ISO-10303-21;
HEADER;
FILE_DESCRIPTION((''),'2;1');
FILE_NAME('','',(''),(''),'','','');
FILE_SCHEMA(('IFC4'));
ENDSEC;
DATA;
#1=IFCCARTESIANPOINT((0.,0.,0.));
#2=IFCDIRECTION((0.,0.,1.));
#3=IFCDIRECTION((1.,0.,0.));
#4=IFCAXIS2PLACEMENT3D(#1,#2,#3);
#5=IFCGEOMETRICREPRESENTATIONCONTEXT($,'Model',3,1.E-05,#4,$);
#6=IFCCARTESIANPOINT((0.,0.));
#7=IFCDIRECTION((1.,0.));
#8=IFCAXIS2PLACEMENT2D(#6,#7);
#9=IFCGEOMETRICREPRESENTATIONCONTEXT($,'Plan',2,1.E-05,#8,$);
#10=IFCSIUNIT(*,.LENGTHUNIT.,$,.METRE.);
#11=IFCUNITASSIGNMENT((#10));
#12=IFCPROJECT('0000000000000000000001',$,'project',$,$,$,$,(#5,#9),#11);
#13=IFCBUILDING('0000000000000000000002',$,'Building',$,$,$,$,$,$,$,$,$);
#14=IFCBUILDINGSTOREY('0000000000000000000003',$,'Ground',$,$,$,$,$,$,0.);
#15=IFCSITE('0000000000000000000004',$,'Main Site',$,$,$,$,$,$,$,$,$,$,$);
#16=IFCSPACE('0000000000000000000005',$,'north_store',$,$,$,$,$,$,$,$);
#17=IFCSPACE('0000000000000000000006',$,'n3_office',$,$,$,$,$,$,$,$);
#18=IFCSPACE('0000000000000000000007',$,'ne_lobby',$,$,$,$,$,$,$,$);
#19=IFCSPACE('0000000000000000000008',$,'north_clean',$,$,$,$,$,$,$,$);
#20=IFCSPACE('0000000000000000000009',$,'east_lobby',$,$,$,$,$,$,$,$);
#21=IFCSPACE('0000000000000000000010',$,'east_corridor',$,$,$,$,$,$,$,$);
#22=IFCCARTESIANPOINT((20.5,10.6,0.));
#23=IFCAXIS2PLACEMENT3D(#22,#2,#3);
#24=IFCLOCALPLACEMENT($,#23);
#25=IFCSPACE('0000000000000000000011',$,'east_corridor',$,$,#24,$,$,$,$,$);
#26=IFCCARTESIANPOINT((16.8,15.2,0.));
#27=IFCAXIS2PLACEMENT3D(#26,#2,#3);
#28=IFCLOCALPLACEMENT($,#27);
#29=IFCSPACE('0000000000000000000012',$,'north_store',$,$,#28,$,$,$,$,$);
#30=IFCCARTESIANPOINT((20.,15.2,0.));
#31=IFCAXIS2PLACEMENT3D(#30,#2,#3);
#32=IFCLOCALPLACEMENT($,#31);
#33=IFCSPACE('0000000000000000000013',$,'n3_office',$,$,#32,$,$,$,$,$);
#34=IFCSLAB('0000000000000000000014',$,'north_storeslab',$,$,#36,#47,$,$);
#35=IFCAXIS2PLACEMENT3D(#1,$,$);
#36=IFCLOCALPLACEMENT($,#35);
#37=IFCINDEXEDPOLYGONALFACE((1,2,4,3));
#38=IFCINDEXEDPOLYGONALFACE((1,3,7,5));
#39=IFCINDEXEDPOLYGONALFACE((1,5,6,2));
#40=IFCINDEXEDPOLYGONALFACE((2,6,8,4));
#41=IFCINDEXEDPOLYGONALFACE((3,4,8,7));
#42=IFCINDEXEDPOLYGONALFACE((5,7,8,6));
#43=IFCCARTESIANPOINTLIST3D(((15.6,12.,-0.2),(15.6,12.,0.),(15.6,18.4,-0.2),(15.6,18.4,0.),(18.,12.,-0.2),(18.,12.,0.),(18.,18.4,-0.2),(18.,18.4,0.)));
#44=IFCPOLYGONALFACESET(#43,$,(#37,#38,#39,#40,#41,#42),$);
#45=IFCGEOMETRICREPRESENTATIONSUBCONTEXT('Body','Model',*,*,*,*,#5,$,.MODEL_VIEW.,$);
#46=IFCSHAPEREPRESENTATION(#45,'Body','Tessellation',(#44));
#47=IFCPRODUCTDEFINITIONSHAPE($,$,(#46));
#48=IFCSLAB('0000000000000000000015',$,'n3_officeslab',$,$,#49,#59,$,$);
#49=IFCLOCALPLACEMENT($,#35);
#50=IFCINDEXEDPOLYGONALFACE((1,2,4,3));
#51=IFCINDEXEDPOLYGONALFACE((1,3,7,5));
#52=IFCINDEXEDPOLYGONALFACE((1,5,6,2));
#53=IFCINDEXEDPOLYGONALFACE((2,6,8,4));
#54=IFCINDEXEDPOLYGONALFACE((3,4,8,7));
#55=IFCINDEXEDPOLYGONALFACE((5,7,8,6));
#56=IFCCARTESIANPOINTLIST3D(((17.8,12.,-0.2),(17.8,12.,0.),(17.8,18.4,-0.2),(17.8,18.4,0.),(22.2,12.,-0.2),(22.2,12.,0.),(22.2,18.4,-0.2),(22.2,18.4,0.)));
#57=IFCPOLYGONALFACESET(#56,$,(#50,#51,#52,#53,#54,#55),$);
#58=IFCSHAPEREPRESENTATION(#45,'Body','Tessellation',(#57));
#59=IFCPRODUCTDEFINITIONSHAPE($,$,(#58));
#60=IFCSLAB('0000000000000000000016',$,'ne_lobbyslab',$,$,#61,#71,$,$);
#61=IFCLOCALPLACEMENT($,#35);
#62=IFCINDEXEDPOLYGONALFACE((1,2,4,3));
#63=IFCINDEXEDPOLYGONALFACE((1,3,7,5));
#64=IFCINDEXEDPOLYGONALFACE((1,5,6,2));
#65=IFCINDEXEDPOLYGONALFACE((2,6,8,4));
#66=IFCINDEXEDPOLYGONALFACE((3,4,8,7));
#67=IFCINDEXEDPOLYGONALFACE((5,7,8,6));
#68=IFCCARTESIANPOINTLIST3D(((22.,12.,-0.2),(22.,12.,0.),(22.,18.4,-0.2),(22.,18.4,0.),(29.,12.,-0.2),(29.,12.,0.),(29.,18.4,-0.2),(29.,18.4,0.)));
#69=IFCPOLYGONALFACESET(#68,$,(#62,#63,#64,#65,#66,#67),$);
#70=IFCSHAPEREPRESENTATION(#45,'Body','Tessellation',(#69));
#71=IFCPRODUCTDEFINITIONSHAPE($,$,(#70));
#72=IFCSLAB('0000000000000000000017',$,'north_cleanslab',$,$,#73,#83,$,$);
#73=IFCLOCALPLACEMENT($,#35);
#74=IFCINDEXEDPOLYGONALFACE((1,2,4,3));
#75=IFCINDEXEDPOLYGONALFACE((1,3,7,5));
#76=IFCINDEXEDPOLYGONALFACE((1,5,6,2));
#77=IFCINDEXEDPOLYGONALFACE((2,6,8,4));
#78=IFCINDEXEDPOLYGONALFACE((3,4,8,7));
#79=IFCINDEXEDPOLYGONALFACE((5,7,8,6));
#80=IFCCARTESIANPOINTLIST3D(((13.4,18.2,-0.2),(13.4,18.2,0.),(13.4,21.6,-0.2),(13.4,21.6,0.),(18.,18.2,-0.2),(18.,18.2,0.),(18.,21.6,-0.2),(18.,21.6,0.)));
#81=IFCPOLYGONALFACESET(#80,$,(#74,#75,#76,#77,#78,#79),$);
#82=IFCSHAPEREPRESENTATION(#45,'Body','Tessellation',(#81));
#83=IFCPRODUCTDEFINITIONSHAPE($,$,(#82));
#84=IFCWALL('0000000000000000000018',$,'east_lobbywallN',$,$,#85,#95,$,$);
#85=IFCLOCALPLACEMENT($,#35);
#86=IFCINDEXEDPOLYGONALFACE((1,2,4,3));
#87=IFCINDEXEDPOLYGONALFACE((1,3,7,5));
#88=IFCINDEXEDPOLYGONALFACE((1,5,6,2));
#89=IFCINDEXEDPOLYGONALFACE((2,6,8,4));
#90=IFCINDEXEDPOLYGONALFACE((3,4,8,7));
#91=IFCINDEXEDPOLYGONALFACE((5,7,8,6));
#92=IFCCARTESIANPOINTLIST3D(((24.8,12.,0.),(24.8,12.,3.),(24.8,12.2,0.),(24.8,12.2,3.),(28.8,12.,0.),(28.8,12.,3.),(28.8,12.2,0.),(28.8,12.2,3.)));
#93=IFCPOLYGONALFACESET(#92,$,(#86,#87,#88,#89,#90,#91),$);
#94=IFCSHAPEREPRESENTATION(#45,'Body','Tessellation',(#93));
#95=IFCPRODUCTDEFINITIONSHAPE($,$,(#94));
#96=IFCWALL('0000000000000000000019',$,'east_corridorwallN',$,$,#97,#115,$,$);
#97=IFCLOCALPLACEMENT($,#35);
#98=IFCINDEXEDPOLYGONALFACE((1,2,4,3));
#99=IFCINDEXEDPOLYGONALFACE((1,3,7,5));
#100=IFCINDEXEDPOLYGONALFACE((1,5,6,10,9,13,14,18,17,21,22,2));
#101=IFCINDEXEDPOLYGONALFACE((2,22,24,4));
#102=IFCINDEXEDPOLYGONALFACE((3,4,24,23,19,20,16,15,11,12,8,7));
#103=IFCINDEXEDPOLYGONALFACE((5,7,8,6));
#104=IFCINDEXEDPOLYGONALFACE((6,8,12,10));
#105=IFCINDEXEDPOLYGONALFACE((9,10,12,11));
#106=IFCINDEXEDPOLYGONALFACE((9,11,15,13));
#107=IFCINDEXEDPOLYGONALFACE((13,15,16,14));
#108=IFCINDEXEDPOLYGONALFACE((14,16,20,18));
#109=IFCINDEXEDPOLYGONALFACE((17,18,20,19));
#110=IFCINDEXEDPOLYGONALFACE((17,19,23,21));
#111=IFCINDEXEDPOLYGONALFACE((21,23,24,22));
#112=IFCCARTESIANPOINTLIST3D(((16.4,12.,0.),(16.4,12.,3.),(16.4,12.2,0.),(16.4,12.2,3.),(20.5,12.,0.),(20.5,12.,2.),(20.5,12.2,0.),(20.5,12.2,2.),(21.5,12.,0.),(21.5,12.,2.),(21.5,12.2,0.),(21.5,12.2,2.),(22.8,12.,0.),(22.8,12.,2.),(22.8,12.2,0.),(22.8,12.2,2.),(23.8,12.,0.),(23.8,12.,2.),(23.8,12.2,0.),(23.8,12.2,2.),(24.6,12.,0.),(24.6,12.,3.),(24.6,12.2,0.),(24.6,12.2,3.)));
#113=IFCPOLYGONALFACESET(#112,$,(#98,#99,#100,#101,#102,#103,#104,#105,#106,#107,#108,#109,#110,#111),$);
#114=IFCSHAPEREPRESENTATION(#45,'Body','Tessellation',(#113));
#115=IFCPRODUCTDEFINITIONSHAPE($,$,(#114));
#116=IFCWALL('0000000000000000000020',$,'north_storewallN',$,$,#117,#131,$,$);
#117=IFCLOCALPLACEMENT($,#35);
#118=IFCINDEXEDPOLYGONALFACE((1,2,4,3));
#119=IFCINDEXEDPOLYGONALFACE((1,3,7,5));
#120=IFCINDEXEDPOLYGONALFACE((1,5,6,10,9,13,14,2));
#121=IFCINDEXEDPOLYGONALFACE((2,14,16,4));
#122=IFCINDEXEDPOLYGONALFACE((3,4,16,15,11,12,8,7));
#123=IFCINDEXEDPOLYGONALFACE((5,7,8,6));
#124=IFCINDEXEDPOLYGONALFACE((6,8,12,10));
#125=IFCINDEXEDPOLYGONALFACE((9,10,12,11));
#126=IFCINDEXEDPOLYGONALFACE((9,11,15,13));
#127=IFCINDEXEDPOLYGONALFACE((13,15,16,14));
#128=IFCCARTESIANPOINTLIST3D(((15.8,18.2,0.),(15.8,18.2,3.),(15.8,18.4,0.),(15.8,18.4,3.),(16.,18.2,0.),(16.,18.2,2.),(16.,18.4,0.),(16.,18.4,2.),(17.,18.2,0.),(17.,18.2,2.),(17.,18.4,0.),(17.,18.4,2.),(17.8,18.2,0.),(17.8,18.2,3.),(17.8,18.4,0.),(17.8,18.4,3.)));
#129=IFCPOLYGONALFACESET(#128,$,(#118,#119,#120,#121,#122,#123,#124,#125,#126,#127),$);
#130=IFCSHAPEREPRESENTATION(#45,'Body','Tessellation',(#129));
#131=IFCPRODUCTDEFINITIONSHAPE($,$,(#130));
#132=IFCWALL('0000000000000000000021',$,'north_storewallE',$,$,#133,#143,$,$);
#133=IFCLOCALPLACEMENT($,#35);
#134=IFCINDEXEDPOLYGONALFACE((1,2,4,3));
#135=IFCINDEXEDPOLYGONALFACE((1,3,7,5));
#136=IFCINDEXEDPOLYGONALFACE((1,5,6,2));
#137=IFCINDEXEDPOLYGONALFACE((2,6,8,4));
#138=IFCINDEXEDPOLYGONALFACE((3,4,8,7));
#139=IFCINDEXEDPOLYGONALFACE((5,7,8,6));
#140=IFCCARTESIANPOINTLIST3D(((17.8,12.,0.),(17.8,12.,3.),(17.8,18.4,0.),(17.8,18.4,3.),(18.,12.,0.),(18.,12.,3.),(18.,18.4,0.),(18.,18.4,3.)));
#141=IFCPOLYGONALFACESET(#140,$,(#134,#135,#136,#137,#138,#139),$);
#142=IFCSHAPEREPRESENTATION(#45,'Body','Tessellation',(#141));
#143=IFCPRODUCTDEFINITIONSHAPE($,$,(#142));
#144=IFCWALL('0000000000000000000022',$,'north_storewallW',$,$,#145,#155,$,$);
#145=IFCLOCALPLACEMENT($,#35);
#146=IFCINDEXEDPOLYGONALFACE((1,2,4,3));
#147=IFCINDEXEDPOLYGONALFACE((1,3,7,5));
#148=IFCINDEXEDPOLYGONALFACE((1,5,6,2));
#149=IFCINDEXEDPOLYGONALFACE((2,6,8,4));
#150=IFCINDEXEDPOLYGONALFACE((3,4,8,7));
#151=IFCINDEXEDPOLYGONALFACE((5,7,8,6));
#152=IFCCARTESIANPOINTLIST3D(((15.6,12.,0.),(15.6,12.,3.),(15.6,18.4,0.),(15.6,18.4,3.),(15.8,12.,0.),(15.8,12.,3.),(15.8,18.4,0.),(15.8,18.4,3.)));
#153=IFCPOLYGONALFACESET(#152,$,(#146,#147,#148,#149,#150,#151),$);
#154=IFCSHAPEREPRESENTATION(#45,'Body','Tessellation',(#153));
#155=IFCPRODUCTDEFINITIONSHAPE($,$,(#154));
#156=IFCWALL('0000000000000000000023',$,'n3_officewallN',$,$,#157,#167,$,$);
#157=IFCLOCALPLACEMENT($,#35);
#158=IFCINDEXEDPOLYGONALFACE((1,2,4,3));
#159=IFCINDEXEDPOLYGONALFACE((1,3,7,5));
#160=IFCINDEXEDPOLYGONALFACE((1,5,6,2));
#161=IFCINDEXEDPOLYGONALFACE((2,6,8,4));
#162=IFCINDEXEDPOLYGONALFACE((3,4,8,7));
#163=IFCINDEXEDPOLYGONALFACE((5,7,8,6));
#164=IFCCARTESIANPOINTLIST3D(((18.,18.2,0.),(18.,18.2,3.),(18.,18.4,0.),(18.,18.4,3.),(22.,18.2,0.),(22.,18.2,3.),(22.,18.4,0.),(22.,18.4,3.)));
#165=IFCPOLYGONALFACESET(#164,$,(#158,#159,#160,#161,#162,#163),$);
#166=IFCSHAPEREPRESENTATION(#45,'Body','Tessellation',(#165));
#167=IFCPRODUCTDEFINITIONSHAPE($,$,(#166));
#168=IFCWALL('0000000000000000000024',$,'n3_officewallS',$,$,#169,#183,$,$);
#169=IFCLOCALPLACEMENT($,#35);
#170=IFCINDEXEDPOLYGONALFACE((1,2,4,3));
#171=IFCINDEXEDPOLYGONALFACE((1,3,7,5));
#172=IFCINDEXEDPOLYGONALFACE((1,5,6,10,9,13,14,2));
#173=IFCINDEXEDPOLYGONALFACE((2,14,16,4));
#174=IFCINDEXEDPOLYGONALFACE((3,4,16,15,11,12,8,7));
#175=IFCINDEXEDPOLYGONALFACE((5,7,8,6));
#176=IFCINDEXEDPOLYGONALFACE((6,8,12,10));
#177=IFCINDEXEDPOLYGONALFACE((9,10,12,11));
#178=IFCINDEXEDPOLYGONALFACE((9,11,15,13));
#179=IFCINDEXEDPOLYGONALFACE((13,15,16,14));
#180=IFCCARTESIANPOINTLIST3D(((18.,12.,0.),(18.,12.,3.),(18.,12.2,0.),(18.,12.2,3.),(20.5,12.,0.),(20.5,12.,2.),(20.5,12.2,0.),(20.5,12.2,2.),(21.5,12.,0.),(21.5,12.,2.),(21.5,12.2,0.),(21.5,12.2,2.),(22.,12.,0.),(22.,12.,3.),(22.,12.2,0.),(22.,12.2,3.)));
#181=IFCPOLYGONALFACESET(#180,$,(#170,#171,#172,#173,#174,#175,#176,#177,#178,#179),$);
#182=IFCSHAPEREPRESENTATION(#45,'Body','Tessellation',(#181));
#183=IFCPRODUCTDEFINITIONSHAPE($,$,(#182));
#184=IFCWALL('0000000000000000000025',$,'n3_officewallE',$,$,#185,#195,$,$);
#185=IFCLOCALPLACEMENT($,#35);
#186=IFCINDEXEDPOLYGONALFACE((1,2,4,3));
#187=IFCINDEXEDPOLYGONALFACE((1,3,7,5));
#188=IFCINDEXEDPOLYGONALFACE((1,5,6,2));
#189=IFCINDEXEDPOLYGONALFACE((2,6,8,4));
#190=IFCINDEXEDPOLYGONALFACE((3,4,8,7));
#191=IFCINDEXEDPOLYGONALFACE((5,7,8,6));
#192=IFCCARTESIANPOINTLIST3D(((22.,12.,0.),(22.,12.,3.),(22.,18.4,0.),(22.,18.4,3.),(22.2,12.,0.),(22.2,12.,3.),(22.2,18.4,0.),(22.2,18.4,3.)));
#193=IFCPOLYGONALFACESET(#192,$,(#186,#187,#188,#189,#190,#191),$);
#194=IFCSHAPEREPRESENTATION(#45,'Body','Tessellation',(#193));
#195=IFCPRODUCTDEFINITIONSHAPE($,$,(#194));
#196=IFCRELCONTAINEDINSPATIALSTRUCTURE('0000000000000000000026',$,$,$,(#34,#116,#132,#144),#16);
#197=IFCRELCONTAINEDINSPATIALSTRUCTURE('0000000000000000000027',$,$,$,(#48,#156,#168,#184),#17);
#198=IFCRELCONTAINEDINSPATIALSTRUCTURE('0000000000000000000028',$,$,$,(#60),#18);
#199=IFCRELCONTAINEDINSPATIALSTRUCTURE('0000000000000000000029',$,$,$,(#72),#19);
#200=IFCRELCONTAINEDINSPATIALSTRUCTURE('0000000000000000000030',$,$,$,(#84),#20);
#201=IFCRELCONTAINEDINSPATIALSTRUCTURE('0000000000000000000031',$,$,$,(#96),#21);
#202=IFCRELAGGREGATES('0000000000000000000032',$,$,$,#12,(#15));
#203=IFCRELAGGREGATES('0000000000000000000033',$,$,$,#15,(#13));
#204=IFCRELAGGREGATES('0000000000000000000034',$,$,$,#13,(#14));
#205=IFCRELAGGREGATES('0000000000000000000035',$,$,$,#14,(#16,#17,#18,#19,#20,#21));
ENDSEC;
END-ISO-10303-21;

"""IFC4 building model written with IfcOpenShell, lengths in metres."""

from ifc_helpers import new_model, si_unit, frame, origin_with_axes, origin_2d_with_axis, place, context, subcontext, project, spatial, indexed_curve, rectangle, outline, extrude, element, save


model = new_model("IFC4")

# Units and contexts
model_context = context("Model", 3, precision=1e-05, world=origin_with_axes())
plan_context = context("Plan", 2, precision=1e-05, world=origin_2d_with_axis())
body_context = subcontext(model_context, "Body", "Model", "MODEL_VIEW")
ifc_project = project(units=[si_unit("LENGTHUNIT", "METRE")], contexts=[model_context, plan_context])

# Site, building, storey, space
site = spatial("IfcSite", under=ifc_project, Name="Main Site")
building = spatial("IfcBuilding", under=site, Name="Building")
storey = spatial("IfcBuildingStorey", under=building, Name="Ground", Elevation=0.0)
space_1 = spatial("IfcSpace", under=storey, Name="north_store")

# Slab
slab_1_placement = place(None, frame((16.8, 15.2, -0.2), z_axis=(0.0, 0.0, 1.0), x_axis=(1.0, 0.0, 0.0)))
element("IfcSlab", 1, at=slab_1_placement, inside=space_1, Name="north_storeslab", context=body_context, shape_type="SweptSolid", body=[
    extrude(rectangle(XDim=2.4, YDim=6.4), origin_with_axes(), (0.0, 0.0, 1.0), 0.2),
])

# Shared definitions
space_2 = spatial("IfcSpace", under=storey, Name="n3_office")

# Slab
slab_2_placement = place(None, frame((20.0, 15.2, -0.2), z_axis=(0.0, 0.0, 1.0), x_axis=(1.0, 0.0, 0.0)))
element("IfcSlab", 2, at=slab_2_placement, inside=space_2, Name="n3_officeslab", context=body_context, shape_type="SweptSolid", body=[
    extrude(rectangle(XDim=4.4, YDim=6.4), origin_with_axes(), (0.0, 0.0, 1.0), 0.2),
])

# Shared definitions
space_3 = spatial("IfcSpace", under=storey, Name="ne_lobby")

# Slab
slab_3_placement = place(None, frame((25.5, 15.2, -0.2), z_axis=(0.0, 0.0, 1.0), x_axis=(1.0, 0.0, 0.0)))
element("IfcSlab", 3, at=slab_3_placement, inside=space_3, Name="ne_lobbyslab", context=body_context, shape_type="SweptSolid", body=[
    extrude(rectangle(XDim=7.0, YDim=6.4), origin_with_axes(), (0.0, 0.0, 1.0), 0.2),
])

# Shared definitions
space_4 = spatial("IfcSpace", under=storey, Name="north_clean")

# Slab
slab_4_placement = place(None, frame((15.7, 19.9, -0.2), z_axis=(0.0, 0.0, 1.0), x_axis=(1.0, 0.0, 0.0)))
element("IfcSlab", 4, at=slab_4_placement, inside=space_4, Name="north_cleanslab", context=body_context, shape_type="SweptSolid", body=[
    extrude(rectangle(XDim=4.6, YDim=3.4), origin_with_axes(), (0.0, 0.0, 1.0), 0.2),
])

# Shared definitions
space_5 = spatial("IfcSpace", under=storey, Name="east_lobby")

# Wall
wall_1_placement = place(None, frame((24.8, 12.0, 0.0), z_axis=(0.0, 0.0, 1.0), x_axis=(1.0, 0.0, 0.0)))
element("IfcWall", 5, at=wall_1_placement, inside=space_5, Name="east_lobbywallN", context=body_context, shape_type="SweptSolid", body=[
    extrude(outline(indexed_curve([(0.0, 0.0), (0.0, 0.2), (4.0, 0.2), (4.0, 0.0), (0.0, 0.0)], self_intersect=False)), origin_with_axes(), (0.0, 0.0, 1.0), 3.0),
])

# Shared definitions
space_6 = spatial("IfcSpace", under=storey, Name="east_corridor")

# Wall
wall_2_placement = place(None, frame((16.4, 12.0, 0.0), z_axis=(0.0, 0.0, 1.0), x_axis=(1.0, 0.0, 0.0)))
wall_2 = element("IfcWall", 6, at=wall_2_placement, inside=space_6, Name="east_corridorwallN", context=body_context, shape_type="SweptSolid", body=[
    extrude(outline(indexed_curve([(0.0, 0.0), (0.0, 0.2), (8.2, 0.2), (8.2, 0.0), (0.0, 0.0)], self_intersect=False)), origin_with_axes(), (0.0, 0.0, 1.0), 3.0),
])

# Shared definitions
space_7_placement = place(None, frame((20.5, 10.6, 0.0), z_axis=(0.0, 0.0, 1.0), x_axis=(1.0, 0.0, 0.0)))
space_7 = spatial("IfcSpace", at=space_7_placement, Name="east_corridor")

# Openings
opening_1_placement = place(wall_2_placement, frame((4.1, 0.0, 0.0), z_axis=(0.0, 0.0, 1.0), x_axis=(1.0, 0.0, 0.0)))
element("IfcOpeningElement", 7, at=opening_1_placement, inside=space_7, cuts=wall_2, context=body_context, shape_type="SweptSolid", body=[
    extrude(outline(indexed_curve([(0.0, 0.0), (0.0, 0.4), (1.0, 0.4), (1.0, 0.0), (0.0, 0.0)], self_intersect=False)), origin_with_axes(), (0.0, 0.0, 1.0), 2.0),
])
opening_2_placement = place(wall_2_placement, frame((6.4, 0.0, 0.0), z_axis=(0.0, 0.0, 1.0), x_axis=(1.0, 0.0, 0.0)))
element("IfcOpeningElement", 8, at=opening_2_placement, inside=space_7, cuts=wall_2, context=body_context, shape_type="SweptSolid", body=[
    extrude(outline(indexed_curve([(0.0, 0.0), (0.0, 0.4), (1.0, 0.4), (1.0, 0.0), (0.0, 0.0)], self_intersect=False)), origin_with_axes(), (0.0, 0.0, 1.0), 2.0),
])

# Wall
wall_3_placement = place(None, frame((15.8, 18.2, 0.0), z_axis=(0.0, 0.0, 1.0), x_axis=(1.0, 0.0, 0.0)))
wall_3 = element("IfcWall", 9, at=wall_3_placement, inside=space_1, Name="north_storewallN", context=body_context, shape_type="SweptSolid", body=[
    extrude(outline(indexed_curve([(0.0, 0.0), (0.0, 0.2), (2.0, 0.2), (2.0, 0.0), (0.0, 0.0)], self_intersect=False)), origin_with_axes(), (0.0, 0.0, 1.0), 3.0),
])

# Shared definitions
space_8_placement = place(None, frame((16.8, 15.2, 0.0), z_axis=(0.0, 0.0, 1.0), x_axis=(1.0, 0.0, 0.0)))
space_8 = spatial("IfcSpace", at=space_8_placement, Name="north_store")

# Opening
opening_3_placement = place(wall_3_placement, frame((0.2, 0.0, 0.0), z_axis=(0.0, 0.0, 1.0), x_axis=(1.0, 0.0, 0.0)))
element("IfcOpeningElement", 10, at=opening_3_placement, inside=space_8, cuts=wall_3, context=body_context, shape_type="SweptSolid", body=[
    extrude(outline(indexed_curve([(0.0, 0.0), (0.0, 0.4), (1.0, 0.4), (1.0, 0.0), (0.0, 0.0)], self_intersect=False)), origin_with_axes(), (0.0, 0.0, 1.0), 2.0),
])

# Walls
for number, where, z_axis, x_axis, name in (
    (11, (18.0, 12.0, 0.0), (0.0, 0.0, 1.0), (0.0, 1.0, 0.0), "north_storewallE"),
    (12, (15.8, 12.0, 0.0), (0.0, 0.0, 1.0), (0.0, 1.0, 0.0), "north_storewallW"),
):
    element("IfcWall", number, at=place(None, frame(where, z_axis=z_axis, x_axis=x_axis)), inside=space_1, Name=name, context=body_context, shape_type="SweptSolid", body=[
        extrude(outline(indexed_curve([(0.0, 0.0), (0.0, 0.2), (6.4, 0.2), (6.4, 0.0), (0.0, 0.0)], self_intersect=False)), origin_with_axes(), (0.0, 0.0, 1.0), 3.0),
    ])
wall_4_placement = place(None, frame((18.0, 18.2, 0.0), z_axis=(0.0, 0.0, 1.0), x_axis=(1.0, 0.0, 0.0)))
element("IfcWall", 13, at=wall_4_placement, inside=space_2, Name="n3_officewallN", context=body_context, shape_type="SweptSolid", body=[
    extrude(outline(indexed_curve([(0.0, 0.0), (0.0, 0.2), (4.0, 0.2), (4.0, 0.0), (0.0, 0.0)], self_intersect=False)), origin_with_axes(), (0.0, 0.0, 1.0), 3.0),
])

# Wall
wall_5_placement = place(None, frame((18.0, 12.0, 0.0), z_axis=(0.0, 0.0, 1.0), x_axis=(1.0, 0.0, 0.0)))
wall_5 = element("IfcWall", 14, at=wall_5_placement, inside=space_2, Name="n3_officewallS", context=body_context, shape_type="SweptSolid", body=[
    extrude(outline(indexed_curve([(0.0, 0.0), (0.0, 0.2), (4.0, 0.2), (4.0, 0.0), (0.0, 0.0)], self_intersect=False)), origin_with_axes(), (0.0, 0.0, 1.0), 3.0),
])

# Shared definitions
space_9_placement = place(None, frame((20.0, 15.2, 0.0), z_axis=(0.0, 0.0, 1.0), x_axis=(1.0, 0.0, 0.0)))
space_9 = spatial("IfcSpace", at=space_9_placement, Name="n3_office")

# Opening
opening_4_placement = place(wall_5_placement, frame((2.5, 0.0, 0.0), z_axis=(0.0, 0.0, 1.0), x_axis=(1.0, 0.0, 0.0)))
element("IfcOpeningElement", 15, at=opening_4_placement, inside=space_9, cuts=wall_5, context=body_context, shape_type="SweptSolid", body=[
    extrude(outline(indexed_curve([(0.0, 0.0), (0.0, 0.4), (1.0, 0.4), (1.0, 0.0), (0.0, 0.0)], self_intersect=False)), origin_with_axes(), (0.0, 0.0, 1.0), 2.0),
])

# Wall
for number, where, z_axis, x_axis, name in (
    (16, (22.2, 12.0, 0.0), (0.0, 0.0, 1.0), (0.0, 1.0, 0.0), "n3_officewallE"),
):
    element("IfcWall", number, at=place(None, frame(where, z_axis=z_axis, x_axis=x_axis)), inside=space_2, Name=name, context=body_context, shape_type="SweptSolid", body=[
        extrude(outline(indexed_curve([(0.0, 0.0), (0.0, 0.2), (6.4, 0.2), (6.4, 0.0), (0.0, 0.0)], self_intersect=False)), origin_with_axes(), (0.0, 0.0, 1.0), 3.0),
    ])

save(model, "model.ifc")
